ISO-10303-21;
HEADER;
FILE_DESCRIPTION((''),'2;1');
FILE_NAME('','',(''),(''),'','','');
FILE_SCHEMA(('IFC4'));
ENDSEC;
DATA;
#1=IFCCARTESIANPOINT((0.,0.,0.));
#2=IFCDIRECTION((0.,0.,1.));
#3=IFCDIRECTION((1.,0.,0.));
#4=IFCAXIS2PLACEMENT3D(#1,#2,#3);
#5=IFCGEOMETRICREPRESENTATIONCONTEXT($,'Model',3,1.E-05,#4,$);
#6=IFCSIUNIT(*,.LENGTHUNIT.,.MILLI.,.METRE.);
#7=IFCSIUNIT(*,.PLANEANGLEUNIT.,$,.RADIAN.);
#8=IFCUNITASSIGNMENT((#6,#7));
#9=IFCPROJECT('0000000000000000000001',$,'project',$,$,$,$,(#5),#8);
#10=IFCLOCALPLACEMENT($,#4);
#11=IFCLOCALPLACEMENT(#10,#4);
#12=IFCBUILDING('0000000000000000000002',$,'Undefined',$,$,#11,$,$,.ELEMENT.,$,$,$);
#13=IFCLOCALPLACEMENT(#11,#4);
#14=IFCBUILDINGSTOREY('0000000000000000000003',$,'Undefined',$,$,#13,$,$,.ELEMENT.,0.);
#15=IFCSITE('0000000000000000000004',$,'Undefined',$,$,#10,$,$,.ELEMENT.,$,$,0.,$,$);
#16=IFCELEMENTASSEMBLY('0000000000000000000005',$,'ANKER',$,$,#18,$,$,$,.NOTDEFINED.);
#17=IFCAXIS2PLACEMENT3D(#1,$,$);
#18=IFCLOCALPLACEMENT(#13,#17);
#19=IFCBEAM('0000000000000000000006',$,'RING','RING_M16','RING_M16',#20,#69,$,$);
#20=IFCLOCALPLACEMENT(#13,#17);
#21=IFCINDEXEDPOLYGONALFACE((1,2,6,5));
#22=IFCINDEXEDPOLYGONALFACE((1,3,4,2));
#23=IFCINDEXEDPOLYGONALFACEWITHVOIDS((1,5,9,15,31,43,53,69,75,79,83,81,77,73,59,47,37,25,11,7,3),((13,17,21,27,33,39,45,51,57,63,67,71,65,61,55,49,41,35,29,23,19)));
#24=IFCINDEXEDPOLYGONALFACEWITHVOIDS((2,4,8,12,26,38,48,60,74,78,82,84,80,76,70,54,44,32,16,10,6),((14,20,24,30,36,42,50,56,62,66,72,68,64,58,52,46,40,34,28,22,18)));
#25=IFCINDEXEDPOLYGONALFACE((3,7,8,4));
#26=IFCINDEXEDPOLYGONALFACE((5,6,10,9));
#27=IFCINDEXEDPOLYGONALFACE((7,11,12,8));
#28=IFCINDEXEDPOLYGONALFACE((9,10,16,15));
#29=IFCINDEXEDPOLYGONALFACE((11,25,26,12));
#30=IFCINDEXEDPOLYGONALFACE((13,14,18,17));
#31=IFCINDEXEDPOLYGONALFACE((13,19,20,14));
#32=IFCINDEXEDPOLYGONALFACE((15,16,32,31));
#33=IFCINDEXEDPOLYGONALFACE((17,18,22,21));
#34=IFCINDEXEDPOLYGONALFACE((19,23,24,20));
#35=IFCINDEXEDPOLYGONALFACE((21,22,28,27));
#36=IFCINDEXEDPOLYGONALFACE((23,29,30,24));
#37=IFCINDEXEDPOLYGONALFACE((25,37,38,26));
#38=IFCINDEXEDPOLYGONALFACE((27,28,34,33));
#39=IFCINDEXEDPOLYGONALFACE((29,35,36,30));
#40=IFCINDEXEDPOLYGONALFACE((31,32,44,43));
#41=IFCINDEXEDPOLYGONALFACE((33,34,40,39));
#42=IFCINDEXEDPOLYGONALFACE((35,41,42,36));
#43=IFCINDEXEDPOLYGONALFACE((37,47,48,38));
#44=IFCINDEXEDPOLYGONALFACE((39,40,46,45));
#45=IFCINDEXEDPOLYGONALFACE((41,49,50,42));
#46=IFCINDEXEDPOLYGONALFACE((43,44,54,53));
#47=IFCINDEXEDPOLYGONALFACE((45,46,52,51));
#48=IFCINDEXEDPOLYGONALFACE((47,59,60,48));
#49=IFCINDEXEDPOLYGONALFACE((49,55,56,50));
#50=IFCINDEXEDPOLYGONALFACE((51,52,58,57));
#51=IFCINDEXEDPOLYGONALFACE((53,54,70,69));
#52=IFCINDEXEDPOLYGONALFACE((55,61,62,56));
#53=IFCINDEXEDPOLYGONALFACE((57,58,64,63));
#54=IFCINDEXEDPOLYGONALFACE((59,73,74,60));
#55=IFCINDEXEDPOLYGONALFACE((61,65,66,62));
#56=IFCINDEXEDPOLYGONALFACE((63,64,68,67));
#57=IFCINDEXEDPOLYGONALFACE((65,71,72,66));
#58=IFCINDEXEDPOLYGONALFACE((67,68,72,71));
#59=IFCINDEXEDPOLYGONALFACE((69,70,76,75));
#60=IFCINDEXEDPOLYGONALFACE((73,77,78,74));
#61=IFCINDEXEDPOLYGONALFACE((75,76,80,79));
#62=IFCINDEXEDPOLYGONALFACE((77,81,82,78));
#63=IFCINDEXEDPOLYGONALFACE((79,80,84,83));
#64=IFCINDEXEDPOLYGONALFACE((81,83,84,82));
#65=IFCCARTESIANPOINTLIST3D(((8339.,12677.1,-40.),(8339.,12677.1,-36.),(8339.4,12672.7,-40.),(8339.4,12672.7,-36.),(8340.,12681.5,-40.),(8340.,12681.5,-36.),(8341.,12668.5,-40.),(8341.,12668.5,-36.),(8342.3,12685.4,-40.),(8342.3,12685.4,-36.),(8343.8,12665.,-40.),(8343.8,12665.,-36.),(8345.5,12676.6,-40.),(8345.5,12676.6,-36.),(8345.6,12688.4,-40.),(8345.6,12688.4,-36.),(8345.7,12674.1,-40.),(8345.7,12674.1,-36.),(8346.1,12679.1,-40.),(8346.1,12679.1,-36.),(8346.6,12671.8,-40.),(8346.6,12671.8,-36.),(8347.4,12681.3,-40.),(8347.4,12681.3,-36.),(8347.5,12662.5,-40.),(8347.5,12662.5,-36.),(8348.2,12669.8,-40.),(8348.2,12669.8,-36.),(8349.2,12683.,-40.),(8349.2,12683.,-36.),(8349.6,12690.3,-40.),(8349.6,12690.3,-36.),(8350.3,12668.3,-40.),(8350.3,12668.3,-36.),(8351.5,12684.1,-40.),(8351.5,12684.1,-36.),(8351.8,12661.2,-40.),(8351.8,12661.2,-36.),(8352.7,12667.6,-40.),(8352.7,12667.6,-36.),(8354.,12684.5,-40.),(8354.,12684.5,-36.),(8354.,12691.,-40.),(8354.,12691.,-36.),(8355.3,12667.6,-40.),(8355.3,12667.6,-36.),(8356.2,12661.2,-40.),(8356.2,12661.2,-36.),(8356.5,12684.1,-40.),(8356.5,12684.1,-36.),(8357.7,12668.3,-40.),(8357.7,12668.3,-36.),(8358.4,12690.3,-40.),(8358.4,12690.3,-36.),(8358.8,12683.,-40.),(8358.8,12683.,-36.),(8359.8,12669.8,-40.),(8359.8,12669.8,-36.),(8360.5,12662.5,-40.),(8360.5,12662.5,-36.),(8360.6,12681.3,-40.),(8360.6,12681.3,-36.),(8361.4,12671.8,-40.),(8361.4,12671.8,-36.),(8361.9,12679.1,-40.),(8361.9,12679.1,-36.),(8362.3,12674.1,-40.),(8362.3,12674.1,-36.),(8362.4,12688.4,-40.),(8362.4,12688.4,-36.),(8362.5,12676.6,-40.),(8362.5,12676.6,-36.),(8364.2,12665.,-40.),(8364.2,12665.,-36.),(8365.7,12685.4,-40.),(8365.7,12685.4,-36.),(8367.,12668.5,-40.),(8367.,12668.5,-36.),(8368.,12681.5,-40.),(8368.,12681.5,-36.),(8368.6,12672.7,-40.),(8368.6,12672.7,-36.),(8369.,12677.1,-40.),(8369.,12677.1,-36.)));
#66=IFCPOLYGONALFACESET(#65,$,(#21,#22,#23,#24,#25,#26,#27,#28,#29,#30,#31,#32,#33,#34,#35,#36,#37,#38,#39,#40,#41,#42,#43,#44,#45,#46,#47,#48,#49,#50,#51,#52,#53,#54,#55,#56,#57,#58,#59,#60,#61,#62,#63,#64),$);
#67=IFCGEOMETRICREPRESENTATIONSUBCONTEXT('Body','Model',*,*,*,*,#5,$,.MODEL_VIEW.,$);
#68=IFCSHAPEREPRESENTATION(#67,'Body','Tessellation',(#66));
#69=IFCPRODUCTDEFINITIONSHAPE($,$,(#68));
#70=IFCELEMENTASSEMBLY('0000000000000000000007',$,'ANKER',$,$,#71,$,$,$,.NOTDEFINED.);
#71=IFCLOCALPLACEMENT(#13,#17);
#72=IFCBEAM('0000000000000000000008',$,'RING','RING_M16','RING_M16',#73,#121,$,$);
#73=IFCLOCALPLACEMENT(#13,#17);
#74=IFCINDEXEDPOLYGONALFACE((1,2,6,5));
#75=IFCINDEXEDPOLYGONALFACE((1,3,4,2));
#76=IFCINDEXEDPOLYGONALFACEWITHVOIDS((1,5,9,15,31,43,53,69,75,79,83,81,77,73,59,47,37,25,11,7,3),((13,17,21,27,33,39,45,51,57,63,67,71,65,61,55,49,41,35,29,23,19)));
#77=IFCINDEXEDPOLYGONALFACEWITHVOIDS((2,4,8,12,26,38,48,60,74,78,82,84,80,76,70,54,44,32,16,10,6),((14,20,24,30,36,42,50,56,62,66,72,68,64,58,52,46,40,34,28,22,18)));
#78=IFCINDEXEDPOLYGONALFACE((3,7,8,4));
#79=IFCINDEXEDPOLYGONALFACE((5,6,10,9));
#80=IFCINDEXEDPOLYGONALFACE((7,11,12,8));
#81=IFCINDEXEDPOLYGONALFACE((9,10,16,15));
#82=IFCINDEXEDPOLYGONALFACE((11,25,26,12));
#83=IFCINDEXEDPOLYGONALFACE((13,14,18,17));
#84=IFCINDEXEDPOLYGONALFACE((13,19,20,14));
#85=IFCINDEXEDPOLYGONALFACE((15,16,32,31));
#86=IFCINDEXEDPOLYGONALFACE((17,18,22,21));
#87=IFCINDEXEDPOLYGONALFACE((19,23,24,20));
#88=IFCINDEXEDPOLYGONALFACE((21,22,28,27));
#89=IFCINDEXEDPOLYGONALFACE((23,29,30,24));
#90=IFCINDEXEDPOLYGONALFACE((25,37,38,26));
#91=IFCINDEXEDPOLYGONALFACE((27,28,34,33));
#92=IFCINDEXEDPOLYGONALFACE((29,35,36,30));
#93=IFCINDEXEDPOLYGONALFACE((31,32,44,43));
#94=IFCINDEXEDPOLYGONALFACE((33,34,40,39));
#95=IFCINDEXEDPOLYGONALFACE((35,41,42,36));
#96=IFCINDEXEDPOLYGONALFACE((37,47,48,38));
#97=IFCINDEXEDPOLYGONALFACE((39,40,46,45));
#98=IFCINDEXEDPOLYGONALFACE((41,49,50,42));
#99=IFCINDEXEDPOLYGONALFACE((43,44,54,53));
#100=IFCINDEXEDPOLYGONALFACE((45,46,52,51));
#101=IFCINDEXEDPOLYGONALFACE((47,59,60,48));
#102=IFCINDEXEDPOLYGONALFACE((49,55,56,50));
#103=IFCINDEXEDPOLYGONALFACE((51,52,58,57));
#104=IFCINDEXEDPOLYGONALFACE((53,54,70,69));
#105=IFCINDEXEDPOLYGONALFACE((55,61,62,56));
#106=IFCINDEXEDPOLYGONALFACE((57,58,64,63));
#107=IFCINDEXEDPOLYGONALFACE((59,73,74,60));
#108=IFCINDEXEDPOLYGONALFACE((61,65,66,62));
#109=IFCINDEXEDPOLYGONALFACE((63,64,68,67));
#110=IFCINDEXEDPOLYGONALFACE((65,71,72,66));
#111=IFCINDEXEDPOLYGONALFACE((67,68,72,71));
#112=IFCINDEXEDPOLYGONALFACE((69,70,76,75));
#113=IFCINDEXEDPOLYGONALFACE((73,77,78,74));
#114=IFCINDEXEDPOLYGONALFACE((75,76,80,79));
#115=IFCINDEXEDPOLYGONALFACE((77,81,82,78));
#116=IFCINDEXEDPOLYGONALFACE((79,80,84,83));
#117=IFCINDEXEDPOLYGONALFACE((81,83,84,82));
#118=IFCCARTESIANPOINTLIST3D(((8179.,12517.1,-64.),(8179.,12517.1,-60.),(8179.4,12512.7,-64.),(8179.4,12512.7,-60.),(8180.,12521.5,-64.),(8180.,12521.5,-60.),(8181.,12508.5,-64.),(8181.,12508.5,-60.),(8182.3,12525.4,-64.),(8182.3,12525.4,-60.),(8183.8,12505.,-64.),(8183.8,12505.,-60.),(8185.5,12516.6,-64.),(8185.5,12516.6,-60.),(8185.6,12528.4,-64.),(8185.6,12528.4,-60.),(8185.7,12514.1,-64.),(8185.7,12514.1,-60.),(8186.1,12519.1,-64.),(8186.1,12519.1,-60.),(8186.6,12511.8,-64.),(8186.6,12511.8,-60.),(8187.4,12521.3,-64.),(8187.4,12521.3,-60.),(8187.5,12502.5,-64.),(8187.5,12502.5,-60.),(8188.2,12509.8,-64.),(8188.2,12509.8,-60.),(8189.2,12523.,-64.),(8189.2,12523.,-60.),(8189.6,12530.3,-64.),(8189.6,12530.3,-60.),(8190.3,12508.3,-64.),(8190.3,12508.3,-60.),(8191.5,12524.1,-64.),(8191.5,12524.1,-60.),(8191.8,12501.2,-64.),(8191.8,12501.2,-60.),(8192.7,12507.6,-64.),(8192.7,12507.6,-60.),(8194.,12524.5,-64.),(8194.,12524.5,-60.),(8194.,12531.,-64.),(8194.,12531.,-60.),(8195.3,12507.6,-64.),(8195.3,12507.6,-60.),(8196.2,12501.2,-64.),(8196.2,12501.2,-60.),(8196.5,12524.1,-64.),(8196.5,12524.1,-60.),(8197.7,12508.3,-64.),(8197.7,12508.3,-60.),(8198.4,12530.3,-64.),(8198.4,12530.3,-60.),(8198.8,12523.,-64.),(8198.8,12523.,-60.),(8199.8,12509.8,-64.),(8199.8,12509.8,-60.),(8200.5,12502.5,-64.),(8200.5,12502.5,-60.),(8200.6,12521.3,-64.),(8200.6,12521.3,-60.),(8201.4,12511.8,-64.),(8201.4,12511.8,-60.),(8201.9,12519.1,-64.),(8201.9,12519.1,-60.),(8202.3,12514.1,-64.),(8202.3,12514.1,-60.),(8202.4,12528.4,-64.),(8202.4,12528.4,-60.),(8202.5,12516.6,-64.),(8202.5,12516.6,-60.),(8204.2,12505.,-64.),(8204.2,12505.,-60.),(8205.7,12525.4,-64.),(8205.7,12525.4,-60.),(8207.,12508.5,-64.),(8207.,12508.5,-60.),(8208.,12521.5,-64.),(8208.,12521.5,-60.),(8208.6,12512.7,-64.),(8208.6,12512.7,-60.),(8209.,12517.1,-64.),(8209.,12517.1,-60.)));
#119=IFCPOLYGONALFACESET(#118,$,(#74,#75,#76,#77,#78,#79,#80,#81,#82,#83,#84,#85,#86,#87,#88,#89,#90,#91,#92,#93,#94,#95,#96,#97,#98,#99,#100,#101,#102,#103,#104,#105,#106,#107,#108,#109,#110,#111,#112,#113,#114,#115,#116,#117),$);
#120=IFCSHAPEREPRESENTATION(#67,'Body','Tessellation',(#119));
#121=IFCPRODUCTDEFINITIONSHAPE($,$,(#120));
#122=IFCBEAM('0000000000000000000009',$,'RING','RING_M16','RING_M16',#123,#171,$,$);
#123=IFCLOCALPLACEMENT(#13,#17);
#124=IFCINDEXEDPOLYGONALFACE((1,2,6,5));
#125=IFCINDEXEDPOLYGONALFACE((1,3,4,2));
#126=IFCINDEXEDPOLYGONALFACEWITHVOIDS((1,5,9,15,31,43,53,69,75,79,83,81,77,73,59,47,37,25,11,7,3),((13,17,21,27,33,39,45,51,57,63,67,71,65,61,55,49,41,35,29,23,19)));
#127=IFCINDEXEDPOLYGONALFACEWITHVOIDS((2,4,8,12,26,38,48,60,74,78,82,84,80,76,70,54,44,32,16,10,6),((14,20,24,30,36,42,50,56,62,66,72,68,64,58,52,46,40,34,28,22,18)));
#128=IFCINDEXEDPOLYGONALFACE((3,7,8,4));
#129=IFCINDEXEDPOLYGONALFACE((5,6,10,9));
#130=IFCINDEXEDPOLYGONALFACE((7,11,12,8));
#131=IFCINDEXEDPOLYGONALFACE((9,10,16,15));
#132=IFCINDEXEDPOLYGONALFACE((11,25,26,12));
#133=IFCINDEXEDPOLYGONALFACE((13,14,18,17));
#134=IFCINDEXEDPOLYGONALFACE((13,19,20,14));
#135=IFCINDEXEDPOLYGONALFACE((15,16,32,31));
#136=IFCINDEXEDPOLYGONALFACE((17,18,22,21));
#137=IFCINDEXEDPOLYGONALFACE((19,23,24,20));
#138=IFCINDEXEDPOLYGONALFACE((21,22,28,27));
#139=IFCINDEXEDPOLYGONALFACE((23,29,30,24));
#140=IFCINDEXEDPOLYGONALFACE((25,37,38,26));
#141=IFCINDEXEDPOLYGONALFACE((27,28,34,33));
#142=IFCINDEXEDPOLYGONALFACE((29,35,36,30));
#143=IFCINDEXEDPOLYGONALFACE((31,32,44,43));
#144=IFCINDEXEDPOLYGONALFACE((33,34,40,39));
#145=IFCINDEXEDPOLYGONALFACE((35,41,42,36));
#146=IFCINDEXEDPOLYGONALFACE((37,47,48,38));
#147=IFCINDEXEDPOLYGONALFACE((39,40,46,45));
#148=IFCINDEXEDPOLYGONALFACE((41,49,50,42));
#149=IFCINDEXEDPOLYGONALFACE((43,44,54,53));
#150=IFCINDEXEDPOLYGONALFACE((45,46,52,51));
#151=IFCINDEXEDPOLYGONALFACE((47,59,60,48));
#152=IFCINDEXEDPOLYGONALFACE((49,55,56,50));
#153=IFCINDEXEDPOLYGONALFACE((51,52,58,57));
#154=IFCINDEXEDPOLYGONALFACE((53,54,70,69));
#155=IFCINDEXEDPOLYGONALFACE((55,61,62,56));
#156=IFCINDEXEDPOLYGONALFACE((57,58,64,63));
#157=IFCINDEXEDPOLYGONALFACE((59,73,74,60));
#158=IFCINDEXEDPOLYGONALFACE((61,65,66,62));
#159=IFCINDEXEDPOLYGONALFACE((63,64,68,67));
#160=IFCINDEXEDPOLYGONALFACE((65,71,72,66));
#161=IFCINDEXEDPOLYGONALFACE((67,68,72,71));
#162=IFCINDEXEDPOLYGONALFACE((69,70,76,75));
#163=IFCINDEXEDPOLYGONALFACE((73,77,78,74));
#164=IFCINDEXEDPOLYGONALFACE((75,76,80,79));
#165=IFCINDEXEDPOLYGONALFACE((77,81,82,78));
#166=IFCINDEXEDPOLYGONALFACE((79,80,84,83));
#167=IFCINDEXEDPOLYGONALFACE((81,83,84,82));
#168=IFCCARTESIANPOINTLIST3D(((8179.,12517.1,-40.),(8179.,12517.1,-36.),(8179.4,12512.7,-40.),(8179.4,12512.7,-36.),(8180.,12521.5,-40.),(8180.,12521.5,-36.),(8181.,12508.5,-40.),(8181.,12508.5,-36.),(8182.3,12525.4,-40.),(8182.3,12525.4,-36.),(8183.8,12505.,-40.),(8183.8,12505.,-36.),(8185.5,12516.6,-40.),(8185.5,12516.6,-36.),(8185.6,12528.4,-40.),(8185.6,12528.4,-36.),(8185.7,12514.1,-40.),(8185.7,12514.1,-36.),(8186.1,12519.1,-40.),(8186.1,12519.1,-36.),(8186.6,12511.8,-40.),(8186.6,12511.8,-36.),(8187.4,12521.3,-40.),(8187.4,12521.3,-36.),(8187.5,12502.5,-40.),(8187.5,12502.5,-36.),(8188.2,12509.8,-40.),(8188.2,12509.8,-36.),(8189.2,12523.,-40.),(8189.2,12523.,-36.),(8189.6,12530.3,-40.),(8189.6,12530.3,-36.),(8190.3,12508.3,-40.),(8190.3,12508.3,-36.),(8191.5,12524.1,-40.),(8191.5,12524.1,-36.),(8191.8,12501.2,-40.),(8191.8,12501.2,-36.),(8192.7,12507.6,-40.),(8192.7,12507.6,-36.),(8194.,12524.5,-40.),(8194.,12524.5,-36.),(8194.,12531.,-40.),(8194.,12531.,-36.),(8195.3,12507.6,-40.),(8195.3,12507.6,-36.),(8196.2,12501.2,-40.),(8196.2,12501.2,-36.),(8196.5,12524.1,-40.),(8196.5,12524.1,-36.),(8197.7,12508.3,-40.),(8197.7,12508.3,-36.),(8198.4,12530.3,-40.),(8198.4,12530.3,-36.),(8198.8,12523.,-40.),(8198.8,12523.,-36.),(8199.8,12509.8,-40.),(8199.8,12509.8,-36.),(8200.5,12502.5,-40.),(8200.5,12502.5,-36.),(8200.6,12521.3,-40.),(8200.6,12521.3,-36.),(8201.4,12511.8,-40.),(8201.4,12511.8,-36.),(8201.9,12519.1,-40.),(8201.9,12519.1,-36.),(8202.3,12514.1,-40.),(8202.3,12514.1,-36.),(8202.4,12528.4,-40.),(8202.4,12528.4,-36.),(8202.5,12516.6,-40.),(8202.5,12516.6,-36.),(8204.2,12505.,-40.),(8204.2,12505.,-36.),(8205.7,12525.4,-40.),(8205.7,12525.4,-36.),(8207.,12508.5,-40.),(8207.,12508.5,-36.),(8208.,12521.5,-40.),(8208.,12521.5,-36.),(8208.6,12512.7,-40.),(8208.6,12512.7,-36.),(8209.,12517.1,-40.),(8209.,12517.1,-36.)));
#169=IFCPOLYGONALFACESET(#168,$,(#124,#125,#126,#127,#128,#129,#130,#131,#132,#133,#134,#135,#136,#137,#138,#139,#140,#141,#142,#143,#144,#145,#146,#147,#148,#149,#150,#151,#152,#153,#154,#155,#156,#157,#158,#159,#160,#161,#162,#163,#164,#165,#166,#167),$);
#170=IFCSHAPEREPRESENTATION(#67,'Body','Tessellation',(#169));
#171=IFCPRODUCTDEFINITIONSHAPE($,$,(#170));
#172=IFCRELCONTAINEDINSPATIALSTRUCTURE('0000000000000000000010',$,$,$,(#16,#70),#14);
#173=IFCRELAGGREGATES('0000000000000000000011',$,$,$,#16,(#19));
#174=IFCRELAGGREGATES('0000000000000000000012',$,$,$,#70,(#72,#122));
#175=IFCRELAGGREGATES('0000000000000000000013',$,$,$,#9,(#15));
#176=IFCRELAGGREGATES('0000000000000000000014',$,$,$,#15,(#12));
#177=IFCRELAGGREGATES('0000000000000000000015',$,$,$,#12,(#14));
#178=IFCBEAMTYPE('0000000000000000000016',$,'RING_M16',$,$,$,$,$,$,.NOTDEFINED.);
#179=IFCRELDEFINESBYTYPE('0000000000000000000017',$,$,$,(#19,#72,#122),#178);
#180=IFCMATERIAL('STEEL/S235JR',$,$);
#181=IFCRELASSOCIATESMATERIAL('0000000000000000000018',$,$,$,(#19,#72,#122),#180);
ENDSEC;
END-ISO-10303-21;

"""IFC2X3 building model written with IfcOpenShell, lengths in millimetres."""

from ifc_helpers import new_model, si_unit, frame, origin_with_axes, origin_2d_with_axis, place, context, subcontext, project, spatial, hollow_circle, extrude, material, type_object, element, aggregate, save


model = new_model("IFC2X3")

# Units and contexts
model_context = context("Model", 3, precision=1e-05, world=origin_with_axes())
body_context = subcontext(model_context, "Body", "Model", "MODEL_VIEW")
ifc_project = project(units=[si_unit("LENGTHUNIT", "METRE", prefix="MILLI"), si_unit("PLANEANGLEUNIT", "RADIAN")], contexts=[model_context])

# Site, building, storey
site_placement = place(None, origin_with_axes())
site = spatial("IfcSite", under=ifc_project, at=site_placement, Name="Undefined", CompositionType="ELEMENT", RefElevation=0.0)
building_placement = place(site_placement, origin_with_axes())
building = spatial("IfcBuilding", under=site, at=building_placement, Name="Undefined", CompositionType="ELEMENT")
storey_placement = place(building_placement, origin_with_axes())
storey = spatial("IfcBuildingStorey", under=building, at=storey_placement, Name="Undefined", CompositionType="ELEMENT", Elevation=0.0)

# Shared definitions
ifc_material = material(Name="STEEL/S235JR")

# Element assemblies, beams
beam_type_1 = type_object("IfcBeamType", Name="RING_M16", PredefinedType="NOTDEFINED")
assembly_1_placement = place(storey_placement, frame((8354.0, 12676.0, 10.0), z_axis=(-1.0, 0.0, 0.0), x_axis=(0.0, 0.0, -1.0)))
assembly_1 = element("IfcElementAssembly", 1, at=assembly_1_placement, inside=storey, Name="ANKER", PredefinedType="NOTDEFINED")
beam_1_placement = place(storey_placement, frame((8354.0, 12676.0, -36.0), z_axis=(-1.0, 0.0, 0.0), x_axis=(0.0, 0.0, -1.0)))
beam_1 = element("IfcBeam", 2, at=beam_1_placement, type_object=beam_type_1, material=ifc_material, Name="RING", Description="RING_M16", ObjectType="RING_M16", context=body_context, shape_type="SweptSolid", body=[
    extrude(hollow_circle(Radius=15.0, WallThickness=6.5, at=origin_2d_with_axis()), frame((4.0, 0.0, 0.0), z_axis=(-1.0, 0.0, 0.0), x_axis=(0.0, -1.0, 0.0)), (0.0, 0.0, 1.0), 4.0),
])
aggregate(assembly_1, [beam_1])
assembly_2_placement = place(storey_placement, frame((8194.0, 12516.0, 10.0), z_axis=(-1.0, 0.0, 0.0), x_axis=(0.0, 0.0, -1.0)))
assembly_2 = element("IfcElementAssembly", 3, at=assembly_2_placement, inside=storey, Name="ANKER", PredefinedType="NOTDEFINED")
beam_2_placement = place(storey_placement, frame((8194.0, 12516.0, -60.0), z_axis=(-1.0, 0.0, 0.0), x_axis=(0.0, 0.0, -1.0)))
beam_2 = element("IfcBeam", 4, at=beam_2_placement, type_object=beam_type_1, material=ifc_material, Name="RING", Description="RING_M16", ObjectType="RING_M16", context=body_context, shape_type="SweptSolid", body=[
    extrude(hollow_circle(Radius=15.0, WallThickness=6.5, at=origin_2d_with_axis()), frame((4.0, 0.0, 0.0), z_axis=(-1.0, 0.0, 0.0), x_axis=(0.0, -1.0, 0.0)), (0.0, 0.0, 1.0), 4.0),
])
beam_3_placement = place(storey_placement, frame((8194.0, 12516.0, -36.0), z_axis=(-1.0, 0.0, 0.0), x_axis=(0.0, 0.0, -1.0)))
beam_3 = element("IfcBeam", 5, at=beam_3_placement, type_object=beam_type_1, material=ifc_material, Name="RING", Description="RING_M16", ObjectType="RING_M16", context=body_context, shape_type="SweptSolid", body=[
    extrude(hollow_circle(Radius=15.0, WallThickness=6.5, at=origin_2d_with_axis()), frame((4.0, 0.0, 0.0), z_axis=(-1.0, 0.0, 0.0), x_axis=(0.0, -1.0, 0.0)), (0.0, 0.0, 1.0), 4.0),
])
aggregate(assembly_2, [beam_2, beam_3])

save(model, "model.ifc")
